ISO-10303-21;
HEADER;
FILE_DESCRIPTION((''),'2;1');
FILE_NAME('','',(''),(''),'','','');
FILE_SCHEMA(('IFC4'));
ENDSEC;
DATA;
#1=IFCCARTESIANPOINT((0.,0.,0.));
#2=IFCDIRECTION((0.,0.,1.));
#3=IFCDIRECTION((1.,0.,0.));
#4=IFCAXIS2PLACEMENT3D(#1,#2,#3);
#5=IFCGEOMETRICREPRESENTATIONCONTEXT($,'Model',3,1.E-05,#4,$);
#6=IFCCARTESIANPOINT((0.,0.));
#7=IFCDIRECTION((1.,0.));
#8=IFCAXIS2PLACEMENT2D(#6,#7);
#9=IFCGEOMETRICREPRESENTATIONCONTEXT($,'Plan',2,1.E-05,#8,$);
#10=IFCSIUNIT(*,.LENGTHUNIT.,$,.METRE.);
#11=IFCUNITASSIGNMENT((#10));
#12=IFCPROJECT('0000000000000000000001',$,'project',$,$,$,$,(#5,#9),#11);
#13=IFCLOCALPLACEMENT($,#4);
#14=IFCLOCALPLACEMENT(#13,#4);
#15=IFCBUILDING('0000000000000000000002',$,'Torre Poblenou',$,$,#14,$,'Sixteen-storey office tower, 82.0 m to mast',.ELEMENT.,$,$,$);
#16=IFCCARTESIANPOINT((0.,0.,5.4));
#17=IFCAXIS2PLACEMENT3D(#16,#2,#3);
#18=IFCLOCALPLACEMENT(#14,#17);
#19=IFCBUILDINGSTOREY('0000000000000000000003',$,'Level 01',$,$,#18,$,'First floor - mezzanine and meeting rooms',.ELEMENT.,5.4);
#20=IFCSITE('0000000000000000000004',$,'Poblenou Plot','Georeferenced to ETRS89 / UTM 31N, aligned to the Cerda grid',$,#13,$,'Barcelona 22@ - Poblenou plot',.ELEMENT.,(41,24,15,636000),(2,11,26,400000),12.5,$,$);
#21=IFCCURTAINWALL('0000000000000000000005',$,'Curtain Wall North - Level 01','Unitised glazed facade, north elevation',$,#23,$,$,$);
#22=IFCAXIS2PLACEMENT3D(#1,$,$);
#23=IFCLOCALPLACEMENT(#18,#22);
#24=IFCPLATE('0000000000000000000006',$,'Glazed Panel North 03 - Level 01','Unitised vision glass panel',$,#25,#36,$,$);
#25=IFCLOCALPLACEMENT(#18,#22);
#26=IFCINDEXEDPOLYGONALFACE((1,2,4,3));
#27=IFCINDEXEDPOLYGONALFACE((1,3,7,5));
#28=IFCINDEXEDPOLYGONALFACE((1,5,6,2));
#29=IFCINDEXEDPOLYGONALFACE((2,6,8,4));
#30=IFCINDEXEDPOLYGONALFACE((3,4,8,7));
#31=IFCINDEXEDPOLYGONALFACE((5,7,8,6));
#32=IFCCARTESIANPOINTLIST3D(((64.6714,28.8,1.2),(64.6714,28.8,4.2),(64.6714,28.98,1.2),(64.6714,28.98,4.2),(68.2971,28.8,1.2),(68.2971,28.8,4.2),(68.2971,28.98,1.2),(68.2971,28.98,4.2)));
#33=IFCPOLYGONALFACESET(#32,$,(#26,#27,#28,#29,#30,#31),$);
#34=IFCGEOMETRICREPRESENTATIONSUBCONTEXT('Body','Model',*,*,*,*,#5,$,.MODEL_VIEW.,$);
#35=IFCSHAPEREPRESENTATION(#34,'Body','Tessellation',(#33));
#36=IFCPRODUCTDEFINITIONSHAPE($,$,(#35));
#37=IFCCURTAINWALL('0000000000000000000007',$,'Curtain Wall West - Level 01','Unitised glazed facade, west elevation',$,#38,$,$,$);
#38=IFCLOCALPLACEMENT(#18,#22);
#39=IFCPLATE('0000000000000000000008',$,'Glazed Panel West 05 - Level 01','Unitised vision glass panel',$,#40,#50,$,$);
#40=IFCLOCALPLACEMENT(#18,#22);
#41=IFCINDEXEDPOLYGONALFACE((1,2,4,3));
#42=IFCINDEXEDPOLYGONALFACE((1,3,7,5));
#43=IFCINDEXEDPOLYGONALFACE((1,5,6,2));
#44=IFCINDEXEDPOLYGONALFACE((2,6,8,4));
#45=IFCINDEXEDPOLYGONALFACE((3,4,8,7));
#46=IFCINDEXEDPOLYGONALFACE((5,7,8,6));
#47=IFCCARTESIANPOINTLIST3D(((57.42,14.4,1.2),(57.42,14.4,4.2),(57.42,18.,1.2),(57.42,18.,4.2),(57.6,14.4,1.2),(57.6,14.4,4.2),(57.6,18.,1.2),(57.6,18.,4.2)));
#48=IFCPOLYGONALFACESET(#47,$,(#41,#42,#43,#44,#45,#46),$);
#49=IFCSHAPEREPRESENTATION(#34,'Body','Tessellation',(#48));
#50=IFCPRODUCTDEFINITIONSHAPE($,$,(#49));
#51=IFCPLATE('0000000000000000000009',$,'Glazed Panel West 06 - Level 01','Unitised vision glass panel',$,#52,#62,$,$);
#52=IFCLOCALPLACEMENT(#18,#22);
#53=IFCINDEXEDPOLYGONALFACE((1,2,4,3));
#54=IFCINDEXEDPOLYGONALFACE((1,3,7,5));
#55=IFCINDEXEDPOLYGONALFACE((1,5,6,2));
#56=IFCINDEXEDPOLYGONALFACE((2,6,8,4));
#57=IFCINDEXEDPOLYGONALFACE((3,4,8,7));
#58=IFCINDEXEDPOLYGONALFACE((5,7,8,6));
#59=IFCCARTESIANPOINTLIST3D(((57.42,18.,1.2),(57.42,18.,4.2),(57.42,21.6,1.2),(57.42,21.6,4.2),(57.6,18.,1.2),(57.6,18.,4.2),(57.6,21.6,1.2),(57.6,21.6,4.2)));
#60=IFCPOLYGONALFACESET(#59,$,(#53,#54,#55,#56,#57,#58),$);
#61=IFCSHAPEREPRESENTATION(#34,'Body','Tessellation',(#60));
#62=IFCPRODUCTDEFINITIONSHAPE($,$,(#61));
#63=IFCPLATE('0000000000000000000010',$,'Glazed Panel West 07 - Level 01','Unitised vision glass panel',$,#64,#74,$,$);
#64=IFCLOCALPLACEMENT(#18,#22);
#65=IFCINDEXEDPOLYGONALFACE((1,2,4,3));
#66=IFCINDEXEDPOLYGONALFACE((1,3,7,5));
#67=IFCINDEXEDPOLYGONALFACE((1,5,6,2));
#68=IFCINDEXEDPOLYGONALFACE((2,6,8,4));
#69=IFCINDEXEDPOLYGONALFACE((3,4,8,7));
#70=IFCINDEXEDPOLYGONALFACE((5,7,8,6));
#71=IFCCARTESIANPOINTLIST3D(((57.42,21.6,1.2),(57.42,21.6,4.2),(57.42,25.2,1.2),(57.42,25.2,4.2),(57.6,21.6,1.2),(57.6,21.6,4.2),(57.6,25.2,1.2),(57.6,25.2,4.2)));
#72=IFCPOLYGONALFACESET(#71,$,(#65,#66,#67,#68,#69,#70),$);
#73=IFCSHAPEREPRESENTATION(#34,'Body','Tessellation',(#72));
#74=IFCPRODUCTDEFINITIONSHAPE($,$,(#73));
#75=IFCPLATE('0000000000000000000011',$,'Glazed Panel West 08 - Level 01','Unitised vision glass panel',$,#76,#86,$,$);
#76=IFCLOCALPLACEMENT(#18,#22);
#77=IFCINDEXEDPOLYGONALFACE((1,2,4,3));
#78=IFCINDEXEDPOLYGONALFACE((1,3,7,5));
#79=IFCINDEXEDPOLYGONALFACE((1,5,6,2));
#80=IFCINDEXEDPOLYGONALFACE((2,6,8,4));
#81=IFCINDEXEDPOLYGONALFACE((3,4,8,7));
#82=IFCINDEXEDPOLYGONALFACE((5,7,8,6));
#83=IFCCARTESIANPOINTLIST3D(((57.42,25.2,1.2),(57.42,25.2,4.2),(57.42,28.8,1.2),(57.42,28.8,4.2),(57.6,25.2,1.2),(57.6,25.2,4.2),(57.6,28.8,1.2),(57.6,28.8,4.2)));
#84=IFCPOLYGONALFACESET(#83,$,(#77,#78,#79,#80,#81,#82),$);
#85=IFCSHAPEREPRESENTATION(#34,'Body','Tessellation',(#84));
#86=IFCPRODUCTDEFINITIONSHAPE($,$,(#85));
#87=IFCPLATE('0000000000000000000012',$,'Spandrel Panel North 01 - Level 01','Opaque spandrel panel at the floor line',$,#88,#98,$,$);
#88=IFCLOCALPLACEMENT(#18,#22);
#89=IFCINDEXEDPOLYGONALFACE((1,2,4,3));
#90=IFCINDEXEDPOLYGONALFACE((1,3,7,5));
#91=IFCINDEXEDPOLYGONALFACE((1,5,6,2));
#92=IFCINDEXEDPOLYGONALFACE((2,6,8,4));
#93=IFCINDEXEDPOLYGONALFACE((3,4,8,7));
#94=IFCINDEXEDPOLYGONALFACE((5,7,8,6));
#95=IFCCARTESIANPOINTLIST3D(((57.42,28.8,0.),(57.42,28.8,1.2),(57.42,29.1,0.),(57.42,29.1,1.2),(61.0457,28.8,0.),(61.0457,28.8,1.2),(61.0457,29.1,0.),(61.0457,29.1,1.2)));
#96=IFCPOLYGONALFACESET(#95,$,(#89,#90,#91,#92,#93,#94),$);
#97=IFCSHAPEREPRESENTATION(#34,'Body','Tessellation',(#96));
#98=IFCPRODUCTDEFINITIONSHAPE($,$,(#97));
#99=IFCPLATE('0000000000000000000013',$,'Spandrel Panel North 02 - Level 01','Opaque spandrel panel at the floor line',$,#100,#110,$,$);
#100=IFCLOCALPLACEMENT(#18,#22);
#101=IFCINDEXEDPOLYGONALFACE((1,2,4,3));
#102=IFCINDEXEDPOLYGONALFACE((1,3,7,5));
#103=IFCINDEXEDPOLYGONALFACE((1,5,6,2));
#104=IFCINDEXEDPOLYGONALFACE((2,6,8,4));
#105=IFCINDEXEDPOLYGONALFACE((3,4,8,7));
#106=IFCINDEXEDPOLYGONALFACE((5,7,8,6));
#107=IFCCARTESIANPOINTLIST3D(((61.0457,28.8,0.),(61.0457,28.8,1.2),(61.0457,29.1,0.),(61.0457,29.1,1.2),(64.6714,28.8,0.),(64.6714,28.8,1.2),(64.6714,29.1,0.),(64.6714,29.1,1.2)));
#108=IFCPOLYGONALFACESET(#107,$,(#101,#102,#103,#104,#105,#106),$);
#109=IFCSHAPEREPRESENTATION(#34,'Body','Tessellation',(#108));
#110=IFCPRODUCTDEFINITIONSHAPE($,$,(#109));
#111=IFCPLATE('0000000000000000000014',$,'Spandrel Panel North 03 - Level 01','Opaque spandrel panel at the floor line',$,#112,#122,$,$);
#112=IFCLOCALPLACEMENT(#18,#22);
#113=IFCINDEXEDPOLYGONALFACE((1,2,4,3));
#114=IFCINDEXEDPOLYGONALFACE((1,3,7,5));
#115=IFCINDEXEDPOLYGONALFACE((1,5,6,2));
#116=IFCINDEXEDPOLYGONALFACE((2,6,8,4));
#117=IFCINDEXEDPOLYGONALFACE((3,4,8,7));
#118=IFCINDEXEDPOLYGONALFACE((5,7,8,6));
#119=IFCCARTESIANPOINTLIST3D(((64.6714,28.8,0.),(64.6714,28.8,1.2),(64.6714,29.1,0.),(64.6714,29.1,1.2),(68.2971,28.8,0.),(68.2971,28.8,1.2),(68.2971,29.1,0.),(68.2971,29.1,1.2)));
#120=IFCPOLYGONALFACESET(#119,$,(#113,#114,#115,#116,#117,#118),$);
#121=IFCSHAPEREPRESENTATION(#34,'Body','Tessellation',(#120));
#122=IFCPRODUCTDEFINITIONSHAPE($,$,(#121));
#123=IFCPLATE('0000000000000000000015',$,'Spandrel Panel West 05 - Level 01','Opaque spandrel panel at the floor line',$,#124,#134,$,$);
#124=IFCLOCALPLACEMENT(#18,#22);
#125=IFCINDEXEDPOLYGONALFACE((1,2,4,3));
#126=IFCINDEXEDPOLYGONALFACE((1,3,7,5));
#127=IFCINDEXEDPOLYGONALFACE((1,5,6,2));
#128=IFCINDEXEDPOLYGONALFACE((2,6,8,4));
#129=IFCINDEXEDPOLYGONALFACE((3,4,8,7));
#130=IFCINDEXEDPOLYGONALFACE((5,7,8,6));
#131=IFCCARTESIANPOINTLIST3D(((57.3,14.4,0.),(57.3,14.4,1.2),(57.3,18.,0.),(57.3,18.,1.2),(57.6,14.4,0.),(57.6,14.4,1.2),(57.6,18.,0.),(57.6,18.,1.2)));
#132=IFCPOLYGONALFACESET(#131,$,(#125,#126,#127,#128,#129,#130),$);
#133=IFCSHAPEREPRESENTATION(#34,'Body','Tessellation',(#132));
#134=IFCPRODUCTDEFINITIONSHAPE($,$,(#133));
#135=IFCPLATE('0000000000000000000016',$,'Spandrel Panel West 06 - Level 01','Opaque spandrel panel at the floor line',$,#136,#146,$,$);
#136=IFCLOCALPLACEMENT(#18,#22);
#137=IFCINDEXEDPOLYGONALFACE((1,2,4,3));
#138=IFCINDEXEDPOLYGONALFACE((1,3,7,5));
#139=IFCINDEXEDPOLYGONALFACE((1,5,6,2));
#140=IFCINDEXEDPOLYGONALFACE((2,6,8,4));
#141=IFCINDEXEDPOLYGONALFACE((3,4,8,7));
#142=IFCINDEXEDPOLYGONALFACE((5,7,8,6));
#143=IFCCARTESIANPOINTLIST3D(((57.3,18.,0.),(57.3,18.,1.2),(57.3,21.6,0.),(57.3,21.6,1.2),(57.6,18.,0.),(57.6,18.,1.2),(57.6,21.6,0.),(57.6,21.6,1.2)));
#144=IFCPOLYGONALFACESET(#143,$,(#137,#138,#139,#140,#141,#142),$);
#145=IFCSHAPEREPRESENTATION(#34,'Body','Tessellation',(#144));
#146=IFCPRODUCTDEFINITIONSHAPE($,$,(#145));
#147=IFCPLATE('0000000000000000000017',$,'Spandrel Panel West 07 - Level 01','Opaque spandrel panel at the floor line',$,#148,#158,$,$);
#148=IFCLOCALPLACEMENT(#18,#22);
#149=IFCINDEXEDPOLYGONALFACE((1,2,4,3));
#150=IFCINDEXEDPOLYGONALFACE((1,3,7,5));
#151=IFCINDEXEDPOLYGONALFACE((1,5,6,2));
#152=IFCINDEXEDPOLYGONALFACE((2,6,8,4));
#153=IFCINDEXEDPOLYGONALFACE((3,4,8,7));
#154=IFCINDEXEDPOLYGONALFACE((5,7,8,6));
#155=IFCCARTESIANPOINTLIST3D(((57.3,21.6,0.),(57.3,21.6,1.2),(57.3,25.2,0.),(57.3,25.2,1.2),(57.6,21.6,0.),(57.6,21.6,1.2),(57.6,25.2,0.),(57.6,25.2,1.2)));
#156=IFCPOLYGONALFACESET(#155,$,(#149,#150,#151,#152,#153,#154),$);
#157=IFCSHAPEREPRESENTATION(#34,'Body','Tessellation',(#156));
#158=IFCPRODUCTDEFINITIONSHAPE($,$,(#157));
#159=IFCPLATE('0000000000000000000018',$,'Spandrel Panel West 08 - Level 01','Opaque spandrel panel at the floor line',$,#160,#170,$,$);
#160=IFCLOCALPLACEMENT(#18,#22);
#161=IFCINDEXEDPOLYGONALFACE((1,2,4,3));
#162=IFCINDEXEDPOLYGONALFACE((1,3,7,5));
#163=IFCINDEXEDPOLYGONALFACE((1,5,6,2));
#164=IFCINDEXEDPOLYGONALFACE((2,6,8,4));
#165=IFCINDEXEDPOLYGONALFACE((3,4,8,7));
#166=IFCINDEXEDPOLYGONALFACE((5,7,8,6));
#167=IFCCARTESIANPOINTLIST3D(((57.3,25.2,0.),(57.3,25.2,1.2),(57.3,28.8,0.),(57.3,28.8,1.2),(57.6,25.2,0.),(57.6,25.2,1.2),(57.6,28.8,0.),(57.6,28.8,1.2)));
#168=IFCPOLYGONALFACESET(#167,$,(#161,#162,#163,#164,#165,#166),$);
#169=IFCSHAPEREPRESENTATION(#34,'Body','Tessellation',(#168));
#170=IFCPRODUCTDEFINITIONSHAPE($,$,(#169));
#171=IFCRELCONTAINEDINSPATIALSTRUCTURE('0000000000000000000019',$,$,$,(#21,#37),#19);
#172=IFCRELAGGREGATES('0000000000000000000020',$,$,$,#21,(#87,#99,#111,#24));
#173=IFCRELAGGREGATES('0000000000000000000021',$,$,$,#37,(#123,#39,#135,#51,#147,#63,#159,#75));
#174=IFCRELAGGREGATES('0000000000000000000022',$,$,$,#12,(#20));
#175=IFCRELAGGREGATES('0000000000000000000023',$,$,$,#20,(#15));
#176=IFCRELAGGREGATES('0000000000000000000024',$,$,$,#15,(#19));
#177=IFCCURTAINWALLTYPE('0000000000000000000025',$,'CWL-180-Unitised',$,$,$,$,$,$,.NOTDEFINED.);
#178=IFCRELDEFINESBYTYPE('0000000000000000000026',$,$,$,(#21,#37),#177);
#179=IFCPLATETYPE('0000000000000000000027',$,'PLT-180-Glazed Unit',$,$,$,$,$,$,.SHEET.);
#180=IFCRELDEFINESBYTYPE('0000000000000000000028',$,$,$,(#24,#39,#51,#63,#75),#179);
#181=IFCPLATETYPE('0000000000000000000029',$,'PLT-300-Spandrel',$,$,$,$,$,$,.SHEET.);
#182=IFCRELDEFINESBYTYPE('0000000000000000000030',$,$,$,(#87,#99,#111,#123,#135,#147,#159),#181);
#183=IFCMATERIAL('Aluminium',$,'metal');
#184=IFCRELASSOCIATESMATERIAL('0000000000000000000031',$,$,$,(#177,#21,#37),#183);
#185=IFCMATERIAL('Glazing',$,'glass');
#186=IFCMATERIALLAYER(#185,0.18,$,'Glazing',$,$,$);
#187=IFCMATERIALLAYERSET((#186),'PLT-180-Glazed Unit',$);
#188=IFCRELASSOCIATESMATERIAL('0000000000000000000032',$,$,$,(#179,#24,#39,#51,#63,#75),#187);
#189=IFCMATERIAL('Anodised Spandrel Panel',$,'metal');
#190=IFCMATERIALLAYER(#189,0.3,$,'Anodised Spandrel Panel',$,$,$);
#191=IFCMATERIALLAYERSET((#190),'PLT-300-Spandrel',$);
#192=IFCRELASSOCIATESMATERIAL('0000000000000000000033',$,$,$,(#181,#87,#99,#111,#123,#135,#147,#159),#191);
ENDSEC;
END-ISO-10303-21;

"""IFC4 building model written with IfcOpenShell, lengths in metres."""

from ifc_helpers import new_model, si_unit, frame, origin_with_axes, origin_2d_with_axis, place, context, subcontext, project, spatial, line, indexed_curve, outline, extrude, material, layer, layer_set, layer_usage, type_object, element, aggregate, save


model = new_model("IFC4")

# Units and contexts
model_context = context("Model", 3, precision=1e-05, world=origin_with_axes())
plan_context = context("Plan", 2, precision=1e-05, world=origin_2d_with_axis())
body_context = subcontext(model_context, "Body", "Model", "MODEL_VIEW")
ifc_project = project(units=[si_unit("LENGTHUNIT", "METRE")], contexts=[model_context, plan_context])

# Site, building, storey
site_placement = place(None, origin_with_axes())
site = spatial("IfcSite", under=ifc_project, at=site_placement, Name="Poblenou Plot", Description="Georeferenced to ETRS89 / UTM 31N, aligned to the Cerda grid", LongName="Barcelona 22@ - Poblenou plot", CompositionType="ELEMENT", RefLatitude=(41, 24, 15, 636000), RefLongitude=(2, 11, 26, 400000), RefElevation=12.5)
building_placement = place(site_placement, origin_with_axes())
building = spatial("IfcBuilding", under=site, at=building_placement, Name="Torre Poblenou", LongName="Sixteen-storey office tower, 82.0 m to mast", CompositionType="ELEMENT")
storey_placement = place(building_placement, frame((0.0, 0.0, 5.4), z_axis=(0.0, 0.0, 1.0), x_axis=(1.0, 0.0, 0.0)))
storey = spatial("IfcBuildingStorey", under=building, at=storey_placement, Name="Level 01", LongName="First floor - mezzanine and meeting rooms", CompositionType="ELEMENT", Elevation=5.4)

# Curtain walls, plates
ifc_material_1 = material(Name="Aluminium", Category="metal")
curtain_wall_type = type_object("IfcCurtainWallType", Name="CWL-180-Unitised", PredefinedType="NOTDEFINED", material=ifc_material_1)
curtain_wall_1_placement = place(storey_placement, frame((57.42, 28.8, 0.0), z_axis=(0.0, 0.0, 1.0), x_axis=(1.0, 0.0, 0.0)))
curtain_wall_1 = element("IfcCurtainWall", 1, at=curtain_wall_1_placement, inside=storey, type_object=curtain_wall_type, material=ifc_material_1, Name="Curtain Wall North - Level 01", Description="Unitised glazed facade, north elevation")
ifc_material_2 = material(Name="Glazing", Category="glass")
ifc_layer_1 = layer(ifc_material_2, 0.18, Name="Glazing")
ifc_layer_set_1 = layer_set([ifc_layer_1], Name="PLT-180-Glazed Unit")
plate_type_1 = type_object("IfcPlateType", Name="PLT-180-Glazed Unit", PredefinedType="SHEET", material=ifc_layer_set_1)
ifc_layer_usage_1 = layer_usage(ifc_layer_set_1, "AXIS2", "POSITIVE", 0.0)
plate_1_placement = place(curtain_wall_1_placement, frame((7.2514, 0.0, 1.2), z_axis=(0.0, 0.0, 1.0), x_axis=(1.0, 0.0, 0.0)))
plate_1 = element("IfcPlate", 2, at=plate_1_placement, type_object=plate_type_1, material=ifc_layer_usage_1, Name="Glazed Panel North 03 - Level 01", Description="Unitised vision glass panel", context=body_context, shape_type="SweptSolid", body=[
    extrude(outline(indexed_curve([(0.0, 0.0), (3.6257, 0.0), (3.6257, 0.18), (0.0, 0.18)], segments=[line(1, 2, 3, 4, 1)])), origin_with_axes(), (0.0, 0.0, 1.0), 3.0),
])
curtain_wall_2_placement = place(storey_placement, frame((57.6, 0.0, 0.0), z_axis=(0.0, 0.0, 1.0), x_axis=(0.0, 1.0, 0.0)))
curtain_wall_2 = element("IfcCurtainWall", 3, at=curtain_wall_2_placement, inside=storey, type_object=curtain_wall_type, material=ifc_material_1, Name="Curtain Wall West - Level 01", Description="Unitised glazed facade, west elevation")
ifc_layer_usage_2 = layer_usage(ifc_layer_set_1, "AXIS2", "POSITIVE", 0.0)
plate_2_placement = place(curtain_wall_2_placement, frame((14.4, 0.0, 1.2), z_axis=(0.0, 0.0, 1.0), x_axis=(1.0, 0.0, 0.0)))
plate_2 = element("IfcPlate", 4, at=plate_2_placement, type_object=plate_type_1, material=ifc_layer_usage_2, Name="Glazed Panel West 05 - Level 01", Description="Unitised vision glass panel", context=body_context, shape_type="SweptSolid", body=[
    extrude(outline(indexed_curve([(0.0, 0.0), (3.6, 0.0), (3.6, 0.18), (0.0, 0.18)], segments=[line(1, 2, 3, 4, 1)])), origin_with_axes(), (0.0, 0.0, 1.0), 3.0),
])
ifc_layer_usage_3 = layer_usage(ifc_layer_set_1, "AXIS2", "POSITIVE", 0.0)
plate_3_placement = place(curtain_wall_2_placement, frame((18.0, 0.0, 1.2), z_axis=(0.0, 0.0, 1.0), x_axis=(1.0, 0.0, 0.0)))
plate_3 = element("IfcPlate", 5, at=plate_3_placement, type_object=plate_type_1, material=ifc_layer_usage_3, Name="Glazed Panel West 06 - Level 01", Description="Unitised vision glass panel", context=body_context, shape_type="SweptSolid", body=[
    extrude(outline(indexed_curve([(0.0, 0.0), (3.6, 0.0), (3.6, 0.18), (0.0, 0.18)], segments=[line(1, 2, 3, 4, 1)])), origin_with_axes(), (0.0, 0.0, 1.0), 3.0),
])
ifc_layer_usage_4 = layer_usage(ifc_layer_set_1, "AXIS2", "POSITIVE", 0.0)
plate_4_placement = place(curtain_wall_2_placement, frame((21.6, 0.0, 1.2), z_axis=(0.0, 0.0, 1.0), x_axis=(1.0, 0.0, 0.0)))
plate_4 = element("IfcPlate", 6, at=plate_4_placement, type_object=plate_type_1, material=ifc_layer_usage_4, Name="Glazed Panel West 07 - Level 01", Description="Unitised vision glass panel", context=body_context, shape_type="SweptSolid", body=[
    extrude(outline(indexed_curve([(0.0, 0.0), (3.6, 0.0), (3.6, 0.18), (0.0, 0.18)], segments=[line(1, 2, 3, 4, 1)])), origin_with_axes(), (0.0, 0.0, 1.0), 3.0),
])
ifc_layer_usage_5 = layer_usage(ifc_layer_set_1, "AXIS2", "POSITIVE", 0.0)
plate_5_placement = place(curtain_wall_2_placement, frame((25.2, 0.0, 1.2), z_axis=(0.0, 0.0, 1.0), x_axis=(1.0, 0.0, 0.0)))
plate_5 = element("IfcPlate", 7, at=plate_5_placement, type_object=plate_type_1, material=ifc_layer_usage_5, Name="Glazed Panel West 08 - Level 01", Description="Unitised vision glass panel", context=body_context, shape_type="SweptSolid", body=[
    extrude(outline(indexed_curve([(0.0, 0.0), (3.6, 0.0), (3.6, 0.18), (0.0, 0.18)], segments=[line(1, 2, 3, 4, 1)])), origin_with_axes(), (0.0, 0.0, 1.0), 3.0),
])

# Plates
ifc_material_3 = material(Name="Anodised Spandrel Panel", Category="metal")
ifc_layer_2 = layer(ifc_material_3, 0.3, Name="Anodised Spandrel Panel")
ifc_layer_set_2 = layer_set([ifc_layer_2], Name="PLT-300-Spandrel")
ifc_layer_usage_6 = layer_usage(ifc_layer_set_2, "AXIS2", "POSITIVE", 0.0)
plate_type_2 = type_object("IfcPlateType", Name="PLT-300-Spandrel", PredefinedType="SHEET", material=ifc_layer_set_2)
plate_6_placement = place(curtain_wall_1_placement, origin_with_axes())
plate_6 = element("IfcPlate", 8, at=plate_6_placement, type_object=plate_type_2, material=ifc_layer_usage_6, Name="Spandrel Panel North 01 - Level 01", Description="Opaque spandrel panel at the floor line", context=body_context, shape_type="SweptSolid", body=[
    extrude(outline(indexed_curve([(0.0, 0.0), (3.6257, 0.0), (3.6257, 0.3), (0.0, 0.3)], segments=[line(1, 2, 3, 4, 1)])), origin_with_axes(), (0.0, 0.0, 1.0), 1.2),
])
ifc_layer_usage_7 = layer_usage(ifc_layer_set_2, "AXIS2", "POSITIVE", 0.0)
plate_7_placement = place(curtain_wall_1_placement, frame((3.6257, 0.0, 0.0), z_axis=(0.0, 0.0, 1.0), x_axis=(1.0, 0.0, 0.0)))
plate_7 = element("IfcPlate", 9, at=plate_7_placement, type_object=plate_type_2, material=ifc_layer_usage_7, Name="Spandrel Panel North 02 - Level 01", Description="Opaque spandrel panel at the floor line", context=body_context, shape_type="SweptSolid", body=[
    extrude(outline(indexed_curve([(0.0, 0.0), (3.6257, 0.0), (3.6257, 0.3), (0.0, 0.3)], segments=[line(1, 2, 3, 4, 1)])), origin_with_axes(), (0.0, 0.0, 1.0), 1.2),
])
ifc_layer_usage_8 = layer_usage(ifc_layer_set_2, "AXIS2", "POSITIVE", 0.0)
plate_8_placement = place(curtain_wall_1_placement, frame((7.2514, 0.0, 0.0), z_axis=(0.0, 0.0, 1.0), x_axis=(1.0, 0.0, 0.0)))
plate_8 = element("IfcPlate", 10, at=plate_8_placement, type_object=plate_type_2, material=ifc_layer_usage_8, Name="Spandrel Panel North 03 - Level 01", Description="Opaque spandrel panel at the floor line", context=body_context, shape_type="SweptSolid", body=[
    extrude(outline(indexed_curve([(0.0, 0.0), (3.6257, 0.0), (3.6257, 0.3), (0.0, 0.3)], segments=[line(1, 2, 3, 4, 1)])), origin_with_axes(), (0.0, 0.0, 1.0), 1.2),
])
aggregate(curtain_wall_1, [plate_6, plate_7, plate_8, plate_1])
ifc_layer_usage_9 = layer_usage(ifc_layer_set_2, "AXIS2", "POSITIVE", 0.0)
plate_9_placement = place(curtain_wall_2_placement, frame((14.4, 0.0, 0.0), z_axis=(0.0, 0.0, 1.0), x_axis=(1.0, 0.0, 0.0)))
plate_9 = element("IfcPlate", 11, at=plate_9_placement, type_object=plate_type_2, material=ifc_layer_usage_9, Name="Spandrel Panel West 05 - Level 01", Description="Opaque spandrel panel at the floor line", context=body_context, shape_type="SweptSolid", body=[
    extrude(outline(indexed_curve([(0.0, 0.0), (3.6, 0.0), (3.6, 0.3), (0.0, 0.3)], segments=[line(1, 2, 3, 4, 1)])), origin_with_axes(), (0.0, 0.0, 1.0), 1.2),
])
ifc_layer_usage_10 = layer_usage(ifc_layer_set_2, "AXIS2", "POSITIVE", 0.0)
plate_10_placement = place(curtain_wall_2_placement, frame((18.0, 0.0, 0.0), z_axis=(0.0, 0.0, 1.0), x_axis=(1.0, 0.0, 0.0)))
plate_10 = element("IfcPlate", 12, at=plate_10_placement, type_object=plate_type_2, material=ifc_layer_usage_10, Name="Spandrel Panel West 06 - Level 01", Description="Opaque spandrel panel at the floor line", context=body_context, shape_type="SweptSolid", body=[
    extrude(outline(indexed_curve([(0.0, 0.0), (3.6, 0.0), (3.6, 0.3), (0.0, 0.3)], segments=[line(1, 2, 3, 4, 1)])), origin_with_axes(), (0.0, 0.0, 1.0), 1.2),
])
ifc_layer_usage_11 = layer_usage(ifc_layer_set_2, "AXIS2", "POSITIVE", 0.0)
plate_11_placement = place(curtain_wall_2_placement, frame((21.6, 0.0, 0.0), z_axis=(0.0, 0.0, 1.0), x_axis=(1.0, 0.0, 0.0)))
plate_11 = element("IfcPlate", 13, at=plate_11_placement, type_object=plate_type_2, material=ifc_layer_usage_11, Name="Spandrel Panel West 07 - Level 01", Description="Opaque spandrel panel at the floor line", context=body_context, shape_type="SweptSolid", body=[
    extrude(outline(indexed_curve([(0.0, 0.0), (3.6, 0.0), (3.6, 0.3), (0.0, 0.3)], segments=[line(1, 2, 3, 4, 1)])), origin_with_axes(), (0.0, 0.0, 1.0), 1.2),
])
ifc_layer_usage_12 = layer_usage(ifc_layer_set_2, "AXIS2", "POSITIVE", 0.0)
plate_12_placement = place(curtain_wall_2_placement, frame((25.2, 0.0, 0.0), z_axis=(0.0, 0.0, 1.0), x_axis=(1.0, 0.0, 0.0)))
plate_12 = element("IfcPlate", 14, at=plate_12_placement, type_object=plate_type_2, material=ifc_layer_usage_12, Name="Spandrel Panel West 08 - Level 01", Description="Opaque spandrel panel at the floor line", context=body_context, shape_type="SweptSolid", body=[
    extrude(outline(indexed_curve([(0.0, 0.0), (3.6, 0.0), (3.6, 0.3), (0.0, 0.3)], segments=[line(1, 2, 3, 4, 1)])), origin_with_axes(), (0.0, 0.0, 1.0), 1.2),
])
aggregate(curtain_wall_2, [plate_9, plate_2, plate_10, plate_3, plate_11, plate_4, plate_12, plate_5])

save(model, "model.ifc")
